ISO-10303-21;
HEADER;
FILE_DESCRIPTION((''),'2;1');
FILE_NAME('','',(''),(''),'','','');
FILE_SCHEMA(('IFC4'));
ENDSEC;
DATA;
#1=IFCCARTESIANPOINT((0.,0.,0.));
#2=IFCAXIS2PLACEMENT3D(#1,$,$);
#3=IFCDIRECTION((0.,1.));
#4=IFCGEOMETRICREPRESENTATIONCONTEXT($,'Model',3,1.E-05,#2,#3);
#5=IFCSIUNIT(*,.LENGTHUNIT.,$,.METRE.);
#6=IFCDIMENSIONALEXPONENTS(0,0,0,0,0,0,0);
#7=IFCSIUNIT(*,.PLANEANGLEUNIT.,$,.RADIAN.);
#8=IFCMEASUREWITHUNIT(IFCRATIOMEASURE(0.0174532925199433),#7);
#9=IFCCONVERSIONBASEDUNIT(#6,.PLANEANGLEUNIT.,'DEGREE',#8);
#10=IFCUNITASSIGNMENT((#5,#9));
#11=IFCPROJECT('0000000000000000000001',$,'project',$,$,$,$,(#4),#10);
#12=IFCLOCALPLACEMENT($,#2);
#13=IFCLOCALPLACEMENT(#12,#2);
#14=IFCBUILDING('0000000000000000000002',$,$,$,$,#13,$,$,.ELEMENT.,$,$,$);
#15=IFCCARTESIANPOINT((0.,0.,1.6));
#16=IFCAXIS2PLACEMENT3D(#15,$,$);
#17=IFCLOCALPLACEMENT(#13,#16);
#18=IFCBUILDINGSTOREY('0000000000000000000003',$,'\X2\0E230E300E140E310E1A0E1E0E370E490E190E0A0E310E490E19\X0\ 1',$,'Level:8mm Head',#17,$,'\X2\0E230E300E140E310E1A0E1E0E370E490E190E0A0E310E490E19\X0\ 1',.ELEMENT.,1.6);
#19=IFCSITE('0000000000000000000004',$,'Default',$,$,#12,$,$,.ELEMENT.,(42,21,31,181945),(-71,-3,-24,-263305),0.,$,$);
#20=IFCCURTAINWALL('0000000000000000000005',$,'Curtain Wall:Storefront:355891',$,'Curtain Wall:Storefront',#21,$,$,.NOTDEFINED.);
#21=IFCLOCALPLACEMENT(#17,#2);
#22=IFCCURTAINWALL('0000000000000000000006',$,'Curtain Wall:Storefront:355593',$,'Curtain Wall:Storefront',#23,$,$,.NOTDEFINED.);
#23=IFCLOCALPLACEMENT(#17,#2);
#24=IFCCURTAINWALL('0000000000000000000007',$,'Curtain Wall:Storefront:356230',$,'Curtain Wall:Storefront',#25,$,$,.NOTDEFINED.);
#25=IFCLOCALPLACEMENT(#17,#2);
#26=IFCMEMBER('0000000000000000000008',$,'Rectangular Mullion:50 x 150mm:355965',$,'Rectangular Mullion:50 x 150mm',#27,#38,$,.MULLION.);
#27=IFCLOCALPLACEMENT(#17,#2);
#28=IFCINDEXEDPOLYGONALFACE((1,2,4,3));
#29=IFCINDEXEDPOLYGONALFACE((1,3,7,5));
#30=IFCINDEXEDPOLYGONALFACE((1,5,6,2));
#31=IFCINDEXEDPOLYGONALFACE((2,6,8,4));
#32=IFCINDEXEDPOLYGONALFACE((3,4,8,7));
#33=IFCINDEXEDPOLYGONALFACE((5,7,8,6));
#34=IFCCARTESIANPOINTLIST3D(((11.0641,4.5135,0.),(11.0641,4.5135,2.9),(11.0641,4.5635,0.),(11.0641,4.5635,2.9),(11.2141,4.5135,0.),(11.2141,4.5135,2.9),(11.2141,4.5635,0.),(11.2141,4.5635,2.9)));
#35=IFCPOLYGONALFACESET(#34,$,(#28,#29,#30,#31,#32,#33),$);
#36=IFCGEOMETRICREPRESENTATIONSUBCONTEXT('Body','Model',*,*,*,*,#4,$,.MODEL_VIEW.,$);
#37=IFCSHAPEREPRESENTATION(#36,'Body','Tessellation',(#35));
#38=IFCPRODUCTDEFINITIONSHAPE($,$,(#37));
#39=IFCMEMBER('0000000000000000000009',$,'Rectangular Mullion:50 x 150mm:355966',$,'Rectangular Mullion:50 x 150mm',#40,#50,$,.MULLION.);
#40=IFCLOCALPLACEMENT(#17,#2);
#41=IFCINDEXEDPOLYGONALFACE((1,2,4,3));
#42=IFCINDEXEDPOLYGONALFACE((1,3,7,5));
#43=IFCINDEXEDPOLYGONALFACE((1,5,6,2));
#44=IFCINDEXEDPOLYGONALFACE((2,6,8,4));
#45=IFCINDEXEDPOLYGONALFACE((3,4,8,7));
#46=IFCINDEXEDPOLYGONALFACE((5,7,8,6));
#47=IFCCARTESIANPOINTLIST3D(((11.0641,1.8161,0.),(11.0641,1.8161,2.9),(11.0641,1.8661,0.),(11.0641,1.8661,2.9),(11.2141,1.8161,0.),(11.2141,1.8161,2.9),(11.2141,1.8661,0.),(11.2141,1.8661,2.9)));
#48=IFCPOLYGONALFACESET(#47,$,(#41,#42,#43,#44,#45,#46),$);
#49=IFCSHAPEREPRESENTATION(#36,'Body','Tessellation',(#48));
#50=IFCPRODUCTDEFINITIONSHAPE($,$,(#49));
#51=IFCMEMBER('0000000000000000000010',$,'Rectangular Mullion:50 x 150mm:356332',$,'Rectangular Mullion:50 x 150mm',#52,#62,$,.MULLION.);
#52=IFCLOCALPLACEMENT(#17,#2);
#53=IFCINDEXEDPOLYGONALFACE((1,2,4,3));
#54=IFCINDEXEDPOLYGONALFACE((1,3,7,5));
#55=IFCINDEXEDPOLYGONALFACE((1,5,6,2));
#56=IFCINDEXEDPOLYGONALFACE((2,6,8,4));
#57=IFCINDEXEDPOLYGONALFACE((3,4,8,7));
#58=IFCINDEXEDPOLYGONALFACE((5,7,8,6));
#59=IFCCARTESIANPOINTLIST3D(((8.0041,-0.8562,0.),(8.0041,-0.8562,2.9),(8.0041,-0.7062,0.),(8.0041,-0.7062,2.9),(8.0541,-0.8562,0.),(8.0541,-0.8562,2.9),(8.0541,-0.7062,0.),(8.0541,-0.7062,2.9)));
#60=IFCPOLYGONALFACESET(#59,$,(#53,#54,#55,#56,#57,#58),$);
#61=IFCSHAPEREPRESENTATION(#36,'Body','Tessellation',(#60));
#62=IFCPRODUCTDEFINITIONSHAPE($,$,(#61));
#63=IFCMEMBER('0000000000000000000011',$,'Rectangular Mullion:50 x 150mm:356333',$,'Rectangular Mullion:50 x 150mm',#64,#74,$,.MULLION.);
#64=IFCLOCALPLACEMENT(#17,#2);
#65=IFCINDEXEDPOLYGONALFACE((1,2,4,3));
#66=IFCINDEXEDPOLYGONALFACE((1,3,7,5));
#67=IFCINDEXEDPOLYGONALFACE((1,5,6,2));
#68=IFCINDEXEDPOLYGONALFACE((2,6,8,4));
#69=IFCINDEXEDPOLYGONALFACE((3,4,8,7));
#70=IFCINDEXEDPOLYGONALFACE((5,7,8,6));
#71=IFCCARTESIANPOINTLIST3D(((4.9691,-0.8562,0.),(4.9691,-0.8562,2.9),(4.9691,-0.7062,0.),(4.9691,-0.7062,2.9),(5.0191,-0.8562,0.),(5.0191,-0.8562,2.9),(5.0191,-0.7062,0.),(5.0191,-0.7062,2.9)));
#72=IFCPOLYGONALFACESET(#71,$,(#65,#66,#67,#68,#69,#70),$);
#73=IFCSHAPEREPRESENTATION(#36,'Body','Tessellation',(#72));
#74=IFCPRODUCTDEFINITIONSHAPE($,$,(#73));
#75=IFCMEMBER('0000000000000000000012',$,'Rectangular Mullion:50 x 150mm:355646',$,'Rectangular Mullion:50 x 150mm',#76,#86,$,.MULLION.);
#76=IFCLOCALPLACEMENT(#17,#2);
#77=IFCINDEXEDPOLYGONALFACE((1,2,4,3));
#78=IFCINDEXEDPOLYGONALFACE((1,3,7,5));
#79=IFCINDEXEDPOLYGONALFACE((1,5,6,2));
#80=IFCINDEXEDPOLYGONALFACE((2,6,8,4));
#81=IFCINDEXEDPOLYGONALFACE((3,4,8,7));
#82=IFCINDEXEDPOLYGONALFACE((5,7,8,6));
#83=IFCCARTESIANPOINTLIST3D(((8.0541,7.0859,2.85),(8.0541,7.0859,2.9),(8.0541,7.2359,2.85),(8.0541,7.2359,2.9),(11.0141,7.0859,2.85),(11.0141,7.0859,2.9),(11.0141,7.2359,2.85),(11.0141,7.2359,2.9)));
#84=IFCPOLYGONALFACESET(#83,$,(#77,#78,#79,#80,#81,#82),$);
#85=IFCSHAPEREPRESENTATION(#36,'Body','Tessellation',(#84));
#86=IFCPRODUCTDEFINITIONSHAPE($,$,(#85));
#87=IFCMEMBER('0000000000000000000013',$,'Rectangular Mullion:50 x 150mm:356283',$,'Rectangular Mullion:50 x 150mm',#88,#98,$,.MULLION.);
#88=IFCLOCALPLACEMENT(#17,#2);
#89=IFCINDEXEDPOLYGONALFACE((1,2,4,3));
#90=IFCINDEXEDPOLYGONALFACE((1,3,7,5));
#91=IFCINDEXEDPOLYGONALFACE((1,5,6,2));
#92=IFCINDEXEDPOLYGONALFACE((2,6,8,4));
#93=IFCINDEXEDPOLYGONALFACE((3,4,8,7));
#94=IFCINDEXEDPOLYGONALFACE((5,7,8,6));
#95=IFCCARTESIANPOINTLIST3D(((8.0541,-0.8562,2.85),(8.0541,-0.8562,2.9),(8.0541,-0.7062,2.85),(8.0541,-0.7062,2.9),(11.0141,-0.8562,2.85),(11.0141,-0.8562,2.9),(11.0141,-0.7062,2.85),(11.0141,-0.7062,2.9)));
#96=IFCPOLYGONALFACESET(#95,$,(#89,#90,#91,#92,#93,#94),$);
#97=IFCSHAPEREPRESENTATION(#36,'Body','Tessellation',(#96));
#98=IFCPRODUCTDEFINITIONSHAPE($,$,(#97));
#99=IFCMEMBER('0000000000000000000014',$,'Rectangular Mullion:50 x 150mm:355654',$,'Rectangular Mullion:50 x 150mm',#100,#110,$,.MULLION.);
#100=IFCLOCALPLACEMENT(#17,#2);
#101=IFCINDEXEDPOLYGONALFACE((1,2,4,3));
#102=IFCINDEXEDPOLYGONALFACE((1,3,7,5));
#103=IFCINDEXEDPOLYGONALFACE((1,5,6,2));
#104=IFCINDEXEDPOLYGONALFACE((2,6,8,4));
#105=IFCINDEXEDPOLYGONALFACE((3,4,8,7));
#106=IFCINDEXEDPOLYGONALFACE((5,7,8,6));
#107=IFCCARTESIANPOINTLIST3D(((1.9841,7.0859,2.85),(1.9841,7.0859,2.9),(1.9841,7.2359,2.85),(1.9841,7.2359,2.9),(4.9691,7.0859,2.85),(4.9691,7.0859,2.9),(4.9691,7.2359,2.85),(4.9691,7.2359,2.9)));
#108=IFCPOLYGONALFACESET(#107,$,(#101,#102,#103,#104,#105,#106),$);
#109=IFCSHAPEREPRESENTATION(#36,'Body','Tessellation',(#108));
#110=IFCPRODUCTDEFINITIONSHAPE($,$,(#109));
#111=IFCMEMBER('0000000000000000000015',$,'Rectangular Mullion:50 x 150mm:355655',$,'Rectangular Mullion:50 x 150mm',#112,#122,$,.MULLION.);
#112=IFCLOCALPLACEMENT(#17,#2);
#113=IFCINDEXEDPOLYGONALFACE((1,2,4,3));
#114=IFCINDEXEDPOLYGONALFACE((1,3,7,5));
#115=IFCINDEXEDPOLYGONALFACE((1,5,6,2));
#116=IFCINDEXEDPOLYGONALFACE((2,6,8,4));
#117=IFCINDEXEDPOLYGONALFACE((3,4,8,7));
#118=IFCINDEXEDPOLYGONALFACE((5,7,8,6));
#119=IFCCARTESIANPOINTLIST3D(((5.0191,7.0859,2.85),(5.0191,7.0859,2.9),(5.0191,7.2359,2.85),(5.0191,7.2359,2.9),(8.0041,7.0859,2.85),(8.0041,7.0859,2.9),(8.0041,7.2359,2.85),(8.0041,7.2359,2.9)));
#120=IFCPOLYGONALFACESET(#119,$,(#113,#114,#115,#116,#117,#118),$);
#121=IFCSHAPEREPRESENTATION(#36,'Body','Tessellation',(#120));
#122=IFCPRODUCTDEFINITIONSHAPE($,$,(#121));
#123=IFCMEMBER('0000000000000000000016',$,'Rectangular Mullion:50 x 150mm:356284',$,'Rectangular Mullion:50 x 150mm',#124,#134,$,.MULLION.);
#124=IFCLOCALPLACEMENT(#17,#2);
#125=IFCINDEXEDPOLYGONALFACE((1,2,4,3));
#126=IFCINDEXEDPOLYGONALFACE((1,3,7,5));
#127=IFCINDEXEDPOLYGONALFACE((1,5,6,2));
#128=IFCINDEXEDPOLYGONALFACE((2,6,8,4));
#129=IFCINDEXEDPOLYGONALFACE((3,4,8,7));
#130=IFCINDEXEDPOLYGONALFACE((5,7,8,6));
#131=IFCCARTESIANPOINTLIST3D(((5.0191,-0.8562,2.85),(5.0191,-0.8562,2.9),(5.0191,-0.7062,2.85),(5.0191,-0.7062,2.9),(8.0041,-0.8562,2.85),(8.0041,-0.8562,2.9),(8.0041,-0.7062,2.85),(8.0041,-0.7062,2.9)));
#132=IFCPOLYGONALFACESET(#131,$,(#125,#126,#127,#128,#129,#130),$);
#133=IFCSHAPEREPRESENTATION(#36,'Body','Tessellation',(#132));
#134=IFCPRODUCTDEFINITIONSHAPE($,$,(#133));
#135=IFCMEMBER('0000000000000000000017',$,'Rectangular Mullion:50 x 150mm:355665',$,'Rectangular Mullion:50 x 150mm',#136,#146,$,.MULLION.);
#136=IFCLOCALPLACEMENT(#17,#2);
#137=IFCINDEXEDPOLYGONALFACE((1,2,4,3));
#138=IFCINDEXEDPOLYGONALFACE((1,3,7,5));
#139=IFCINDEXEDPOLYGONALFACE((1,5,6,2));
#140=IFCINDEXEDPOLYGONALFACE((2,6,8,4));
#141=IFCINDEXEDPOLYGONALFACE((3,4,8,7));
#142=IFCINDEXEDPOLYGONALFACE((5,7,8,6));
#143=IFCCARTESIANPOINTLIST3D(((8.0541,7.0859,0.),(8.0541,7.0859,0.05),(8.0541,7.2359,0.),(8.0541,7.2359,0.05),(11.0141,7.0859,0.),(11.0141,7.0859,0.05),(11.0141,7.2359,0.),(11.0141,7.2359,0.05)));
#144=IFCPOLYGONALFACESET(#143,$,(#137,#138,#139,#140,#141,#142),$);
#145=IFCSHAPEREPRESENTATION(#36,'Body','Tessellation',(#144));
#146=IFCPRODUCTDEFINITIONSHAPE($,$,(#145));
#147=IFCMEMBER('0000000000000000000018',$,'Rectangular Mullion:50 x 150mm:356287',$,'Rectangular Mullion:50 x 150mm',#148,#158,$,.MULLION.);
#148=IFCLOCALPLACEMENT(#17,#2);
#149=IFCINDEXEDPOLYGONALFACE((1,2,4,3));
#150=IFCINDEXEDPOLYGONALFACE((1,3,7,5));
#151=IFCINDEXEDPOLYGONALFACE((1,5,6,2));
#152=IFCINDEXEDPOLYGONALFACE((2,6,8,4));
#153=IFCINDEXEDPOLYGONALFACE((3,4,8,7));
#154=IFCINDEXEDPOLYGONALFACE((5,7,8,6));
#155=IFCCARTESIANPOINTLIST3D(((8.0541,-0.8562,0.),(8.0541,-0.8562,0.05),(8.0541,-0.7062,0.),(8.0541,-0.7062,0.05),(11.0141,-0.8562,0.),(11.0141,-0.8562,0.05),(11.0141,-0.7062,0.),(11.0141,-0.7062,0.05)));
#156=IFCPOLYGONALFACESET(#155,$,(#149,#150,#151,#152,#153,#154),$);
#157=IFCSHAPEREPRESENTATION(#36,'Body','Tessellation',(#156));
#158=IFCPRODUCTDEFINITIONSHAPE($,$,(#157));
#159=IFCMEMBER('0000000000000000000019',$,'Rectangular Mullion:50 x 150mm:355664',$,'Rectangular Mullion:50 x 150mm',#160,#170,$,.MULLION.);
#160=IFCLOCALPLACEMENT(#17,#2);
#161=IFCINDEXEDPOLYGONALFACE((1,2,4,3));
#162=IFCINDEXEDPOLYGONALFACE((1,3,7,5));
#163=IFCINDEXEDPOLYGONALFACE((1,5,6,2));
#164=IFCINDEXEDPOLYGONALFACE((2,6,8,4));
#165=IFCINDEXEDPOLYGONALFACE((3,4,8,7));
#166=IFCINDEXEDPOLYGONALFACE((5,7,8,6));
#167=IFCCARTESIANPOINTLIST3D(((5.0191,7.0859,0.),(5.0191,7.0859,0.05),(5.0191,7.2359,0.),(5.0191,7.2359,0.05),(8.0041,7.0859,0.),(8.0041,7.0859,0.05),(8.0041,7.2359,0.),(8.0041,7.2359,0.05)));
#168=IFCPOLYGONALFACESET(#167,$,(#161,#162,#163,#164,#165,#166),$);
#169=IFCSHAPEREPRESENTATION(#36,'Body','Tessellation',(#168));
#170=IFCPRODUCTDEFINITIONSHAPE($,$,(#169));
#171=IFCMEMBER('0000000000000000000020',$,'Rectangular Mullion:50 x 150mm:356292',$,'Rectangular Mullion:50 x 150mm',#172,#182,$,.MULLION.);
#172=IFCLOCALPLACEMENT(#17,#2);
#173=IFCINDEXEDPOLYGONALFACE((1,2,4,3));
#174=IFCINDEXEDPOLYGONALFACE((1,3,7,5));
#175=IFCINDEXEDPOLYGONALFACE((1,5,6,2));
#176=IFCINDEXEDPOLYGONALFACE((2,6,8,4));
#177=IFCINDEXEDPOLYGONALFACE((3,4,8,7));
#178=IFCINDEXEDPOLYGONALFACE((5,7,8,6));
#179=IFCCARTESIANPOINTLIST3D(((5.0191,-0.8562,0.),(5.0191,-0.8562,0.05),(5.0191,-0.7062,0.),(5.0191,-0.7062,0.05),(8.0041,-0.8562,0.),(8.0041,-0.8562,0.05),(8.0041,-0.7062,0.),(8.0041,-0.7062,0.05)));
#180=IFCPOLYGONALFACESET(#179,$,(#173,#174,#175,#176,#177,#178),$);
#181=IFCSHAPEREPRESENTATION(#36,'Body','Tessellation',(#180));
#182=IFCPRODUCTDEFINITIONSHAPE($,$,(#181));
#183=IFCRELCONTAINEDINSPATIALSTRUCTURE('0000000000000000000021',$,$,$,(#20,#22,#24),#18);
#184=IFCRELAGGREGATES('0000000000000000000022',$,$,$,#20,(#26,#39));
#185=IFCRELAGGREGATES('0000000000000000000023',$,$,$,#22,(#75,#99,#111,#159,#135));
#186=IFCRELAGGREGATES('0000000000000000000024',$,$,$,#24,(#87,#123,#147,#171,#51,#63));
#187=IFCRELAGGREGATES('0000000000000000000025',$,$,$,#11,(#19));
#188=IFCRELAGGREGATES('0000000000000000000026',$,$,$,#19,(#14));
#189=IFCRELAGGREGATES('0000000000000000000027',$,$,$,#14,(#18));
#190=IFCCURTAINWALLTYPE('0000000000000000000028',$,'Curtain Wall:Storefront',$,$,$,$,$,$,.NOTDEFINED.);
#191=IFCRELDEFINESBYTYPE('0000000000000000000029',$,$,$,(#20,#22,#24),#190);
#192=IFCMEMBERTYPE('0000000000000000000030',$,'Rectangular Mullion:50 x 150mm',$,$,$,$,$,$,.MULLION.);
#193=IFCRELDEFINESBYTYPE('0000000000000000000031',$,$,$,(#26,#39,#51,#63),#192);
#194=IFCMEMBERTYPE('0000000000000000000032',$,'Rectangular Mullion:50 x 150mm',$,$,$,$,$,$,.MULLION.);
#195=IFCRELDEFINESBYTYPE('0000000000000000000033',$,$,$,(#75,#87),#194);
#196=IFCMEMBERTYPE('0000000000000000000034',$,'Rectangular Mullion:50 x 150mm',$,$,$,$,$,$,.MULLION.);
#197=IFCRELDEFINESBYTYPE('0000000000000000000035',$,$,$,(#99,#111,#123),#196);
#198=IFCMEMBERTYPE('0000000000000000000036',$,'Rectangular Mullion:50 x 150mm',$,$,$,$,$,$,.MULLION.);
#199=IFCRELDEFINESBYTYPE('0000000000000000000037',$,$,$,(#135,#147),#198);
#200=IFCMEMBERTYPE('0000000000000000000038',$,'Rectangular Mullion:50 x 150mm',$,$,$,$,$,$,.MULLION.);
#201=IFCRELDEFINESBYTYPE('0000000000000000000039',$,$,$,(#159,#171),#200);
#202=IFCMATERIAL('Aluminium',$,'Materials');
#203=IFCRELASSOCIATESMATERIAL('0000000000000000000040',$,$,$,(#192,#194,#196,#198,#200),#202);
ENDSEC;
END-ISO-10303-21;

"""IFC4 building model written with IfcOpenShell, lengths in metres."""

from ifc_helpers import new_model, entity, si_unit, converted_unit, direction, frame, origin, place, context, subcontext, project, spatial, indexed_curve, outline, extrude, source, transform, mapped, material, type_object, type_shapes, element, aggregate, save


model = new_model("IFC4")

# Units and contexts
model_context = context("Model", 3, precision=1e-05, world=origin(), true_north=direction((0.0, 1.0)))
body_context = subcontext(model_context, "Body", "Model", "MODEL_VIEW")
ifc_project = project(units=[si_unit("LENGTHUNIT", "METRE"), converted_unit("PLANEANGLEUNIT", "DEGREE", entity("IfcRatioMeasure", 0.0174532925199433), si_unit("PLANEANGLEUNIT", "RADIAN"), dimensions=[0, 0, 0, 0, 0, 0, 0])], contexts=[model_context])

# Site, building, storey
site_placement = place(None, origin())
site = spatial("IfcSite", under=ifc_project, at=site_placement, Name="Default", CompositionType="ELEMENT", RefLatitude=(42, 21, 31, 181945), RefLongitude=(-71, -3, -24, -263305), RefElevation=0.0)
building_placement = place(site_placement, origin())
building = spatial("IfcBuilding", under=site, at=building_placement, CompositionType="ELEMENT")
storey_placement = place(building_placement, frame((0.0, 0.0, 1.6)))
storey = spatial("IfcBuildingStorey", under=building, at=storey_placement, Name="ระดับพื้นชั้น 1", ObjectType="Level:8mm Head", LongName="ระดับพื้นชั้น 1", CompositionType="ELEMENT", Elevation=1.6)

# Curtain wall
curtain_wall_type = type_object("IfcCurtainWallType", Name="Curtain Wall:Storefront", PredefinedType="NOTDEFINED")
curtain_wall_1_placement = place(storey_placement, frame((0.0, 0.0, -1.6)))
curtain_wall_1 = element("IfcCurtainWall", 1, at=curtain_wall_1_placement, inside=storey, type_object=curtain_wall_type, Name="Curtain Wall:Storefront:355891", ObjectType="Curtain Wall:Storefront", PredefinedType="NOTDEFINED")
ifc_material_1 = material(Name="Aluminium", Category="Materials")

# Curtain wall
curtain_wall_2_placement = place(storey_placement, frame((0.0, 0.0, -1.6)))
curtain_wall_2 = element("IfcCurtainWall", 2, at=curtain_wall_2_placement, inside=storey, type_object=curtain_wall_type, Name="Curtain Wall:Storefront:355593", ObjectType="Curtain Wall:Storefront", PredefinedType="NOTDEFINED")

# Curtain wall
curtain_wall_3_placement = place(storey_placement, frame((0.0, 0.0, -1.6)))
curtain_wall_3 = element("IfcCurtainWall", 3, at=curtain_wall_3_placement, inside=storey, type_object=curtain_wall_type, Name="Curtain Wall:Storefront:356230", ObjectType="Curtain Wall:Storefront", PredefinedType="NOTDEFINED")

# Members
member_type_1 = type_object("IfcMemberType", Name="Rectangular Mullion:50 x 150mm", PredefinedType="MULLION", material=ifc_material_1)
shared_shape_1 = source(origin(), body_context, "Body", "SweptSolid", [
    extrude(outline(indexed_curve([(-0.075, -0.025), (0.075, -0.025), (0.075, 0.025), (-0.075, 0.025), (-0.075, -0.025)], self_intersect=False)), frame((0.0, 0.0, -2.9), z_axis=(0.0, 0.0, 1.0), x_axis=(0.0, -1.0, 0.0)), (0.0, 0.0, 1.0), 2.9),
])
type_shapes(member_type_1, [shared_shape_1])
member_1_placement = place(curtain_wall_1_placement, frame((11.1391, 4.5385, 1.6), z_axis=(0.0, 0.0, -1.0), x_axis=(0.0, -1.0, 0.0)))
member_1 = element("IfcMember", 4, at=member_1_placement, type_object=member_type_1, Name="Rectangular Mullion:50 x 150mm:355965", ObjectType="Rectangular Mullion:50 x 150mm", PredefinedType="MULLION", context=body_context, shape_type="MappedRepresentation", body=[
    mapped(shared_shape_1, transform((0.0, 0.0, 0.0), scale=1.0)),
])
member_2_placement = place(curtain_wall_1_placement, frame((11.1391, 1.8411, 1.6), z_axis=(0.0, 0.0, -1.0), x_axis=(0.0, -1.0, 0.0)))
member_2 = element("IfcMember", 5, at=member_2_placement, type_object=member_type_1, Name="Rectangular Mullion:50 x 150mm:355966", ObjectType="Rectangular Mullion:50 x 150mm", PredefinedType="MULLION", context=body_context, shape_type="MappedRepresentation", body=[
    mapped(shared_shape_1, transform((0.0, 0.0, 0.0), scale=1.0)),
])
member_3_placement = place(curtain_wall_3_placement, frame((8.0291, -0.7812, 1.6), z_axis=(0.0, 0.0, -1.0), x_axis=(-1.0, 0.0, 0.0)))
member_3 = element("IfcMember", 6, at=member_3_placement, type_object=member_type_1, Name="Rectangular Mullion:50 x 150mm:356332", ObjectType="Rectangular Mullion:50 x 150mm", PredefinedType="MULLION", context=body_context, shape_type="MappedRepresentation", body=[
    mapped(shared_shape_1, transform((0.0, 0.0, 0.0), scale=1.0)),
])
member_4_placement = place(curtain_wall_3_placement, frame((4.9941, -0.7812, 1.6), z_axis=(0.0, 0.0, -1.0), x_axis=(-1.0, 0.0, 0.0)))
member_4 = element("IfcMember", 7, at=member_4_placement, type_object=member_type_1, Name="Rectangular Mullion:50 x 150mm:356333", ObjectType="Rectangular Mullion:50 x 150mm", PredefinedType="MULLION", context=body_context, shape_type="MappedRepresentation", body=[
    mapped(shared_shape_1, transform((0.0, 0.0, 0.0), scale=1.0)),
])
member_type_2 = type_object("IfcMemberType", Name="Rectangular Mullion:50 x 150mm", PredefinedType="MULLION", material=ifc_material_1)
shared_shape_2 = source(origin(), body_context, "Body", "SweptSolid", [
    extrude(outline(indexed_curve([(-0.075, -0.025), (0.075, -0.025), (0.075, 0.025), (-0.075, 0.025), (-0.075, -0.025)], self_intersect=False)), frame((-0.025, 0.0, -2.96), z_axis=(0.0, 0.0, 1.0), x_axis=(0.0, -1.0, 0.0)), (0.0, 0.0, 1.0), 2.96),
])
type_shapes(member_type_2, [shared_shape_2])
member_5_placement = place(curtain_wall_2_placement, frame((11.0141, 7.1609, 4.5), z_axis=(1.0, 0.0, 0.0), x_axis=(0.0, 0.0, 1.0)))
member_5 = element("IfcMember", 8, at=member_5_placement, type_object=member_type_2, Name="Rectangular Mullion:50 x 150mm:355646", ObjectType="Rectangular Mullion:50 x 150mm", PredefinedType="MULLION", context=body_context, shape_type="MappedRepresentation", body=[
    mapped(shared_shape_2, transform((0.0, 0.0, 0.0), scale=1.0)),
])
member_6_placement = place(curtain_wall_3_placement, frame((8.0541, -0.7812, 4.5), z_axis=(-1.0, 0.0, 0.0), x_axis=(0.0, 0.0, 1.0)))
member_6 = element("IfcMember", 9, at=member_6_placement, type_object=member_type_2, Name="Rectangular Mullion:50 x 150mm:356283", ObjectType="Rectangular Mullion:50 x 150mm", PredefinedType="MULLION", context=body_context, shape_type="MappedRepresentation", body=[
    mapped(shared_shape_2, transform((0.0, 0.0, 0.0), scale=1.0)),
])
member_type_3 = type_object("IfcMemberType", Name="Rectangular Mullion:50 x 150mm", PredefinedType="MULLION", material=ifc_material_1)
shared_shape_3 = source(origin(), body_context, "Body", "SweptSolid", [
    extrude(outline(indexed_curve([(-0.075, -0.025), (0.075, -0.025), (0.075, 0.025), (-0.075, 0.025), (-0.075, -0.025)], self_intersect=False)), frame((-0.025, 0.0, -2.985), z_axis=(0.0, 0.0, 1.0), x_axis=(0.0, -1.0, 0.0)), (0.0, 0.0, 1.0), 2.985),
])
type_shapes(member_type_3, [shared_shape_3])
member_7_placement = place(curtain_wall_2_placement, frame((4.9691, 7.1609, 4.5), z_axis=(1.0, 0.0, 0.0), x_axis=(0.0, 0.0, 1.0)))
member_7 = element("IfcMember", 10, at=member_7_placement, type_object=member_type_3, Name="Rectangular Mullion:50 x 150mm:355654", ObjectType="Rectangular Mullion:50 x 150mm", PredefinedType="MULLION", context=body_context, shape_type="MappedRepresentation", body=[
    mapped(shared_shape_3, transform((0.0, 0.0, 0.0), scale=1.0)),
])
member_8_placement = place(curtain_wall_2_placement, frame((8.0041, 7.1609, 4.5), z_axis=(1.0, 0.0, 0.0), x_axis=(0.0, 0.0, 1.0)))
member_8 = element("IfcMember", 11, at=member_8_placement, type_object=member_type_3, Name="Rectangular Mullion:50 x 150mm:355655", ObjectType="Rectangular Mullion:50 x 150mm", PredefinedType="MULLION", context=body_context, shape_type="MappedRepresentation", body=[
    mapped(shared_shape_3, transform((0.0, 0.0, 0.0), scale=1.0)),
])
member_9_placement = place(curtain_wall_3_placement, frame((5.0191, -0.7812, 4.5), z_axis=(-1.0, 0.0, 0.0), x_axis=(0.0, 0.0, 1.0)))
member_9 = element("IfcMember", 12, at=member_9_placement, type_object=member_type_3, Name="Rectangular Mullion:50 x 150mm:356284", ObjectType="Rectangular Mullion:50 x 150mm", PredefinedType="MULLION", context=body_context, shape_type="MappedRepresentation", body=[
    mapped(shared_shape_3, transform((0.0, 0.0, 0.0), scale=1.0)),
])
member_type_4 = type_object("IfcMemberType", Name="Rectangular Mullion:50 x 150mm", PredefinedType="MULLION", material=ifc_material_1)
shared_shape_4 = source(origin(), body_context, "Body", "SweptSolid", [
    extrude(outline(indexed_curve([(-0.075, -0.025), (0.075, -0.025), (0.075, 0.025), (-0.075, 0.025), (-0.075, -0.025)], self_intersect=False)), frame((-0.025, 0.0, -2.96), z_axis=(0.0, 0.0, 1.0), x_axis=(0.0, -1.0, 0.0)), (0.0, 0.0, 1.0), 2.96),
])
type_shapes(member_type_4, [shared_shape_4])
member_10_placement = place(curtain_wall_2_placement, frame((8.0541, 7.1609, 1.6), z_axis=(-1.0, 0.0, 0.0), x_axis=(0.0, 0.0, -1.0)))
member_10 = element("IfcMember", 13, at=member_10_placement, type_object=member_type_4, Name="Rectangular Mullion:50 x 150mm:355665", ObjectType="Rectangular Mullion:50 x 150mm", PredefinedType="MULLION", context=body_context, shape_type="MappedRepresentation", body=[
    mapped(shared_shape_4, transform((0.0, 0.0, 0.0), scale=1.0)),
])
member_11_placement = place(curtain_wall_3_placement, frame((11.0141, -0.7812, 1.6), z_axis=(1.0, 0.0, 0.0), x_axis=(0.0, 0.0, -1.0)))
member_11 = element("IfcMember", 14, at=member_11_placement, type_object=member_type_4, Name="Rectangular Mullion:50 x 150mm:356287", ObjectType="Rectangular Mullion:50 x 150mm", PredefinedType="MULLION", context=body_context, shape_type="MappedRepresentation", body=[
    mapped(shared_shape_4, transform((0.0, 0.0, 0.0), scale=1.0)),
])
member_type_5 = type_object("IfcMemberType", Name="Rectangular Mullion:50 x 150mm", PredefinedType="MULLION", material=ifc_material_1)
shared_shape_5 = source(origin(), body_context, "Body", "SweptSolid", [
    extrude(outline(indexed_curve([(-0.075, -0.025), (0.075, -0.025), (0.075, 0.025), (-0.075, 0.025), (-0.075, -0.025)], self_intersect=False)), frame((-0.025, 0.0, -2.985), z_axis=(0.0, 0.0, 1.0), x_axis=(0.0, -1.0, 0.0)), (0.0, 0.0, 1.0), 2.985),
])
type_shapes(member_type_5, [shared_shape_5])
member_12_placement = place(curtain_wall_2_placement, frame((5.0191, 7.1609, 1.6), z_axis=(-1.0, 0.0, 0.0), x_axis=(0.0, 0.0, -1.0)))
member_12 = element("IfcMember", 15, at=member_12_placement, type_object=member_type_5, Name="Rectangular Mullion:50 x 150mm:355664", ObjectType="Rectangular Mullion:50 x 150mm", PredefinedType="MULLION", context=body_context, shape_type="MappedRepresentation", body=[
    mapped(shared_shape_5, transform((0.0, 0.0, 0.0), scale=1.0)),
])
member_13_placement = place(curtain_wall_3_placement, frame((8.0041, -0.7812, 1.6), z_axis=(1.0, 0.0, 0.0), x_axis=(0.0, 0.0, -1.0)))
member_13 = element("IfcMember", 16, at=member_13_placement, type_object=member_type_5, Name="Rectangular Mullion:50 x 150mm:356292", ObjectType="Rectangular Mullion:50 x 150mm", PredefinedType="MULLION", context=body_context, shape_type="MappedRepresentation", body=[
    mapped(shared_shape_5, transform((0.0, 0.0, 0.0), scale=1.0)),
])

aggregate(curtain_wall_1, [member_1, member_2])
aggregate(curtain_wall_2, [member_5, member_7, member_8, member_12, member_10])
aggregate(curtain_wall_3, [member_6, member_9, member_11, member_13, member_3, member_4])

save(model, "model.ifc")
